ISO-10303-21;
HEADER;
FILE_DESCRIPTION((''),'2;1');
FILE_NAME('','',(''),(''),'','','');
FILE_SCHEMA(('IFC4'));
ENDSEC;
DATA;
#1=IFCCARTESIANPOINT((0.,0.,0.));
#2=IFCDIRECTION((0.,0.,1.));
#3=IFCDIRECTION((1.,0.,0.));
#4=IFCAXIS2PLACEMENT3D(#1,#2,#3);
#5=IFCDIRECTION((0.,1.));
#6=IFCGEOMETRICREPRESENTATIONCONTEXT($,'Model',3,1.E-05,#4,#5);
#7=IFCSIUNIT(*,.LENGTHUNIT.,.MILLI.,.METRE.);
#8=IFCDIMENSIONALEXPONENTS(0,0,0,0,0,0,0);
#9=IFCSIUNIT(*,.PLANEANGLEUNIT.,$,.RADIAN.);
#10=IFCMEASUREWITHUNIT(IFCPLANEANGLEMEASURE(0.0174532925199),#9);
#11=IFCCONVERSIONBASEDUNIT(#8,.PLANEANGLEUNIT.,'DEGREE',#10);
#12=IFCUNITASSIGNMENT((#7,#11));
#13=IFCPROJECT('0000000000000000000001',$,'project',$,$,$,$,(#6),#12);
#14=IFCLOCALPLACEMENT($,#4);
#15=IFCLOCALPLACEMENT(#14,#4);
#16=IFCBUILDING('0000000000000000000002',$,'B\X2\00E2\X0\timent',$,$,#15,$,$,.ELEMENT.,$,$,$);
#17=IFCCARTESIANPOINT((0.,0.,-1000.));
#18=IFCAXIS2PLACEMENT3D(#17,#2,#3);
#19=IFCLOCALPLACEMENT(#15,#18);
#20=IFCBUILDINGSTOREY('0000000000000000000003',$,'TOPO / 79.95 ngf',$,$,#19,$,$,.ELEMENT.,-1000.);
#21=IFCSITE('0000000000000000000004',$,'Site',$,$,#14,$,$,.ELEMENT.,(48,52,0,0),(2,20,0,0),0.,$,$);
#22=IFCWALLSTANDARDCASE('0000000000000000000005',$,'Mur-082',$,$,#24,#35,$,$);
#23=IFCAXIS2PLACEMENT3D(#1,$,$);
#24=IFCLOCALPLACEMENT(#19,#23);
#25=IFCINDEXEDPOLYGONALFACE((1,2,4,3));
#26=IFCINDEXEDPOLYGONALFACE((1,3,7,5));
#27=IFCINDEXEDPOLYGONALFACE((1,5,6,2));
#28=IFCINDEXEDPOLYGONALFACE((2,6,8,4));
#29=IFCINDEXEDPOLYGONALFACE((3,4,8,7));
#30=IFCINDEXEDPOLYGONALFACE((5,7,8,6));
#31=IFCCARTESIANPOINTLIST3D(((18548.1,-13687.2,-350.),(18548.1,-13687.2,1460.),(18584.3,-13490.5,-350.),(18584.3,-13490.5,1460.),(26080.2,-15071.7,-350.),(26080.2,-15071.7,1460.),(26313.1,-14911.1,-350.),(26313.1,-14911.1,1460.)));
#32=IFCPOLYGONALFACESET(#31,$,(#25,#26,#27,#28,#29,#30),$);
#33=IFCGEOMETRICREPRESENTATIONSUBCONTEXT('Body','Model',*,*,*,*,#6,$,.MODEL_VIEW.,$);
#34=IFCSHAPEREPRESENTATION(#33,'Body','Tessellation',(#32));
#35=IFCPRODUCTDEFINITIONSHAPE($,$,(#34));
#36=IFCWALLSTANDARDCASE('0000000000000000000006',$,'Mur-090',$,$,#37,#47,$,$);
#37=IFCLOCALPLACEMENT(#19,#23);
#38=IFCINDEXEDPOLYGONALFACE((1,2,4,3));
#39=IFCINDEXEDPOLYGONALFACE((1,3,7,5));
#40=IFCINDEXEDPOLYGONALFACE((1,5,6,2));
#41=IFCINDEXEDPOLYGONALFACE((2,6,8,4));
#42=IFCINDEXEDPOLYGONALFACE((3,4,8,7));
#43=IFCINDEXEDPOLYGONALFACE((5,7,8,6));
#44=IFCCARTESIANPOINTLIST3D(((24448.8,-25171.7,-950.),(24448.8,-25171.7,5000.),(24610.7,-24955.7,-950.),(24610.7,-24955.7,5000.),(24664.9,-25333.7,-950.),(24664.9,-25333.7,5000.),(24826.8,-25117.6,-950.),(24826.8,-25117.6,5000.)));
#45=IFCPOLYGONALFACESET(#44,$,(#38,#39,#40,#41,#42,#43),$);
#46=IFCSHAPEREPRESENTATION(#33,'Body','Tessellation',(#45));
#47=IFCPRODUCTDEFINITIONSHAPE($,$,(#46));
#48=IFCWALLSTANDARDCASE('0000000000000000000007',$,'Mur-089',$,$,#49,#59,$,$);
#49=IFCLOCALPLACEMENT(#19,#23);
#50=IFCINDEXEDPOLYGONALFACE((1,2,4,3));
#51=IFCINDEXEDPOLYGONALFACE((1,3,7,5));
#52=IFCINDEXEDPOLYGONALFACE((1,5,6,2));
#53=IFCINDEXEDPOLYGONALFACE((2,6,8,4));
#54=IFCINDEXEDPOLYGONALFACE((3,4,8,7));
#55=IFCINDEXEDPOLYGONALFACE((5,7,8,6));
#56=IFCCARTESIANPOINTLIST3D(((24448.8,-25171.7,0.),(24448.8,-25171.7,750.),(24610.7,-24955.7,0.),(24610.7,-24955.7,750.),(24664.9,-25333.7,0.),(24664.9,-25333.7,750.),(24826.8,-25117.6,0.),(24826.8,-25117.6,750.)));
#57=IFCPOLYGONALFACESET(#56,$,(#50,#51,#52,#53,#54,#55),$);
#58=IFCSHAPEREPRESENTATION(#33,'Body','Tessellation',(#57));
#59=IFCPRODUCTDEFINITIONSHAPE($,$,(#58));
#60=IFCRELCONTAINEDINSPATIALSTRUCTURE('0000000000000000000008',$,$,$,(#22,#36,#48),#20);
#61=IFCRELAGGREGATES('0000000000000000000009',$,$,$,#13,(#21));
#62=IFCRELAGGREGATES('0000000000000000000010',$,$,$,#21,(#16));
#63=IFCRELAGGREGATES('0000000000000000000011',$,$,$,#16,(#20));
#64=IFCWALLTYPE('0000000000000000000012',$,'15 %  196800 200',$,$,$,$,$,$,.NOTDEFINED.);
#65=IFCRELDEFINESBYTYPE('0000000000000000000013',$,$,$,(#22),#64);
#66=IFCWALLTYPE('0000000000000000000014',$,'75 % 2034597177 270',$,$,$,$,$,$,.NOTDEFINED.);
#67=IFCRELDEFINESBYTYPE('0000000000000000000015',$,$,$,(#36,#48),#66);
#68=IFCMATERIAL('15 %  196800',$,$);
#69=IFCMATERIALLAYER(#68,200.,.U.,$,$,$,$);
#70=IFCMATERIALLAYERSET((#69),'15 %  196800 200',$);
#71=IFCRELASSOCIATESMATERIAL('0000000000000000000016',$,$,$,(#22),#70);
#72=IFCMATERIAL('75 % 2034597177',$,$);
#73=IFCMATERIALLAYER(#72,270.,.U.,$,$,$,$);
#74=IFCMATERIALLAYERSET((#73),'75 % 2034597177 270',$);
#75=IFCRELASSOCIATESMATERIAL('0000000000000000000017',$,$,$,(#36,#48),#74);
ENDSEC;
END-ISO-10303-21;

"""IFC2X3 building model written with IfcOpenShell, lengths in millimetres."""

from ifc_helpers import new_model, entity, si_unit, converted_unit, direction, frame, origin_with_axes, place, context, subcontext, project, spatial, polyline, outline, extrude, material, layer, layer_set, layer_usage, type_object, element, save


model = new_model("IFC2X3")

# Units and contexts
model_context = context("Model", 3, precision=1e-05, world=origin_with_axes(), true_north=direction((0.0, 1.0)))
body_context = subcontext(model_context, "Body", "Model", "MODEL_VIEW")
ifc_project = project(units=[si_unit("LENGTHUNIT", "METRE", prefix="MILLI"), converted_unit("PLANEANGLEUNIT", "DEGREE", entity("IfcPlaneAngleMeasure", 0.0174532925199), si_unit("PLANEANGLEUNIT", "RADIAN"), dimensions=[0, 0, 0, 0, 0, 0, 0])], contexts=[model_context])

# Site, building, storey
site_placement = place(None, origin_with_axes())
site = spatial("IfcSite", under=ifc_project, at=site_placement, Name="Site", CompositionType="ELEMENT", RefLatitude=(48, 52, 0, 0), RefLongitude=(2, 20, 0, 0), RefElevation=0.0)
building_placement = place(site_placement, origin_with_axes())
building = spatial("IfcBuilding", under=site, at=building_placement, Name="Bâtiment", CompositionType="ELEMENT")
storey_placement = place(building_placement, frame((0.0, 0.0, -1000.0), z_axis=(0.0, 0.0, 1.0), x_axis=(1.0, 0.0, 0.0)))
storey = spatial("IfcBuildingStorey", under=building, at=storey_placement, Name="TOPO / 79.95 ngf", CompositionType="ELEMENT", Elevation=-1000.0)

# Walls
ifc_material_1 = material(Name="75 % 2034597177")
ifc_material_2 = material(Name="15 %  196800")
ifc_layer_1 = layer(ifc_material_2, 200.0, ventilated="UNKNOWN")
ifc_layer_set_1 = layer_set([ifc_layer_1], Name="15 %  196800 200")
wall_type_1 = type_object("IfcWallType", Name="15 %  196800 200", PredefinedType="NOTDEFINED")
ifc_layer_usage_1 = layer_usage(ifc_layer_set_1, "AXIS2", "NEGATIVE", 100.0)
wall_1_placement = place(storey_placement, frame((26295.0, -15009.5, -350.0), z_axis=(0.0, 0.0, 1.0), x_axis=(-0.983524, 0.18078, 0.0)))
element("IfcWallStandardCase", 1, at=wall_1_placement, inside=storey, type_object=wall_type_1, material=ifc_layer_usage_1, Name="Mur-082", context=body_context, shape_type="SweptSolid", body=[
    extrude(outline(polyline([(0.0, -100.0), (7858.2, -100.0), (7858.3, 100.0), (200.0, 100.0), (0.0, -100.0)])), origin_with_axes(), (0.0, 0.0, 1.0), 1810.0),
])
ifc_layer_2 = layer(ifc_material_1, 270.0, ventilated="UNKNOWN")
ifc_layer_set_2 = layer_set([ifc_layer_2], Name="75 % 2034597177 270")
ifc_layer_usage_2 = layer_usage(ifc_layer_set_2, "AXIS2", "POSITIVE", -270.0)
wall_type_2 = type_object("IfcWallType", Name="75 % 2034597177 270", PredefinedType="NOTDEFINED")
wall_2_placement = place(storey_placement, frame((24610.7, -24955.7, -950.0), z_axis=(0.0, 0.0, 1.0), x_axis=(0.800255, -0.599659, 0.0)))
element("IfcWallStandardCase", 2, at=wall_2_placement, inside=storey, type_object=wall_type_2, material=ifc_layer_usage_2, Name="Mur-090", context=body_context, shape_type="SweptSolid", body=[
    extrude(outline(polyline([(0.0, -270.0), (270.0, -270.0), (270.0, 0.0), (0.0, 0.0), (0.0, -270.0)])), origin_with_axes(), (0.0, 0.0, 1.0), 5950.0),
])
ifc_layer_usage_3 = layer_usage(ifc_layer_set_2, "AXIS2", "POSITIVE", -270.0)
wall_3_placement = place(storey_placement, frame((24610.7, -24955.7, 0.0), z_axis=(0.0, 0.0, 1.0), x_axis=(0.800255, -0.599659, 0.0)))
element("IfcWallStandardCase", 3, at=wall_3_placement, inside=storey, type_object=wall_type_2, material=ifc_layer_usage_3, Name="Mur-089", context=body_context, shape_type="SweptSolid", body=[
    extrude(outline(polyline([(0.0, -270.0), (270.0, -270.0), (270.0, 0.0), (0.0, 0.0), (0.0, -270.0)])), origin_with_axes(), (0.0, 0.0, 1.0), 750.0),
])

save(model, "model.ifc")
